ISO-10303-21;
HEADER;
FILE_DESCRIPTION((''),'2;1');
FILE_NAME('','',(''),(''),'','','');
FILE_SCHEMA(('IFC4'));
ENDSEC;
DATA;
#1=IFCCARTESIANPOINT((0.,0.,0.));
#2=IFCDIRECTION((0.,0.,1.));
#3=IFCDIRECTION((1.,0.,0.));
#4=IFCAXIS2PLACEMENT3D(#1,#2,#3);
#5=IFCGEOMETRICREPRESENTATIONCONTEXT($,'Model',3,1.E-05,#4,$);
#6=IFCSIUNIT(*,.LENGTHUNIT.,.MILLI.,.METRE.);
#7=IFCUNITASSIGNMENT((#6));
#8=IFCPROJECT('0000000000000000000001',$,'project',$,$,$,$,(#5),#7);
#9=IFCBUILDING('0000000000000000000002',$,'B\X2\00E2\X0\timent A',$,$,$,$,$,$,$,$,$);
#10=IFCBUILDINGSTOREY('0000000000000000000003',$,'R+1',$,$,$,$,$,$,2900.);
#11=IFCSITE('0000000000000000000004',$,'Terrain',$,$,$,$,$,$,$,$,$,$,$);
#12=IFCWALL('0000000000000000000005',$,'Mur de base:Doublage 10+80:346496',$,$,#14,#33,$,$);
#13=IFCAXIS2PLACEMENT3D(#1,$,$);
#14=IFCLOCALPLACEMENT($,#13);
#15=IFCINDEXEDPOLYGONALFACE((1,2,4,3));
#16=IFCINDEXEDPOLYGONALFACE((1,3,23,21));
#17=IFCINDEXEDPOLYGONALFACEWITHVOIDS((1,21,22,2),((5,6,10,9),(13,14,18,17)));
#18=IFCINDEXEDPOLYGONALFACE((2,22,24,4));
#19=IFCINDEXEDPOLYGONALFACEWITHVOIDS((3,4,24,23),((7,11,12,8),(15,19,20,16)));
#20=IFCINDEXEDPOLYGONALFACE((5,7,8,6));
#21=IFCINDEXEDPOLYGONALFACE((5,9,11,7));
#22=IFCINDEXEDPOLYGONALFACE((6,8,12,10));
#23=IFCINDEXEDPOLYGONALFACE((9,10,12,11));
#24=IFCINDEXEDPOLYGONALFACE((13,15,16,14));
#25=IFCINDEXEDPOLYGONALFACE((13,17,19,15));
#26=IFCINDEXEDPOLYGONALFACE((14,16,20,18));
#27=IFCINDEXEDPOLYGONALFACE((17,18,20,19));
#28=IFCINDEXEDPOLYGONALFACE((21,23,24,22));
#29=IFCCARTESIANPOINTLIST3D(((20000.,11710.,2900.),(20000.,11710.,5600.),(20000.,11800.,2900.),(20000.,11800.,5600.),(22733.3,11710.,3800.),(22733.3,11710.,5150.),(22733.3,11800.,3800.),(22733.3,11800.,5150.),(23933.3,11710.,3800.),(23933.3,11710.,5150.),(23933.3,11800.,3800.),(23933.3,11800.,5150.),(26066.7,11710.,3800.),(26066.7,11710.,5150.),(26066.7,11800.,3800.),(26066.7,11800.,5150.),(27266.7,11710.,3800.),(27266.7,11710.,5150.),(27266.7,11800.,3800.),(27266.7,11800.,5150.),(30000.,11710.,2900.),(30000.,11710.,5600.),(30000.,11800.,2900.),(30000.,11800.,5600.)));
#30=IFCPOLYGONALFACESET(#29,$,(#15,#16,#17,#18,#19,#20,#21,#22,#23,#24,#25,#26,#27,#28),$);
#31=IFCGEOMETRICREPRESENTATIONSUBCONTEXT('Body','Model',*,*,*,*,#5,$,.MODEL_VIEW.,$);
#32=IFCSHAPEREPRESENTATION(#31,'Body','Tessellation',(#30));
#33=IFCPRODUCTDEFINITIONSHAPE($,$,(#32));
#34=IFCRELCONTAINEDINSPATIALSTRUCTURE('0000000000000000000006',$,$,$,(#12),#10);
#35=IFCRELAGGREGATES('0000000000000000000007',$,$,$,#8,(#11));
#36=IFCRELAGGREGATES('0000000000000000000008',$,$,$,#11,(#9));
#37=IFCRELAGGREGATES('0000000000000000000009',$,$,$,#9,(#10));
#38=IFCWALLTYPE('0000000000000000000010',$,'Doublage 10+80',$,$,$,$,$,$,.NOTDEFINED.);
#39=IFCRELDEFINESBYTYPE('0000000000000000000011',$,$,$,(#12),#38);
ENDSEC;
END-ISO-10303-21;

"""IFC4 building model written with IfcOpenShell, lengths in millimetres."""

from ifc_helpers import new_model, si_unit, frame, frame_2d, origin_with_axes, place, context, subcontext, project, spatial, rectangle, extrude, type_object, element, save


model = new_model("IFC4")

# Units and contexts
model_context = context("Model", 3, precision=1e-05, world=origin_with_axes())
body_context = subcontext(model_context, "Body", "Model", "MODEL_VIEW")
ifc_project = project(units=[si_unit("LENGTHUNIT", "METRE", prefix="MILLI")], contexts=[model_context])

# Site, building, storey
site = spatial("IfcSite", under=ifc_project, Name="Terrain")
building = spatial("IfcBuilding", under=site, Name="Bâtiment A")
storey = spatial("IfcBuildingStorey", under=building, Name="R+1", Elevation=2900.0)

# Wall, openings
wall_type_1 = type_object("IfcWallType", Name="Doublage 10+80", PredefinedType="NOTDEFINED")
wall_1_placement = place(None, origin_with_axes())
wall_1 = element("IfcWall", 1, at=wall_1_placement, inside=storey, type_object=wall_type_1, Name="Mur de base:Doublage 10+80:346496", context=body_context, shape_type="SweptSolid", body=[
    extrude(rectangle(XDim=10000.0, YDim=90.0, at=frame_2d((25000.0, 11755.0))), frame((0.0, 0.0, 2900.0), z_axis=(0.0, 0.0, 1.0), x_axis=(1.0, 0.0, 0.0)), (0.0, 0.0, 1.0), 2700.0),
])
opening_1_placement = place(None, origin_with_axes())
element("IfcOpeningElement", 2, at=opening_1_placement, cuts=wall_1, context=body_context, shape_type="SweptSolid", body=[
    extrude(rectangle(XDim=1200.0, YDim=210.0, at=frame_2d((23333.3, 11755.0))), frame((0.0, 0.0, 3800.0), z_axis=(0.0, 0.0, 1.0), x_axis=(1.0, 0.0, 0.0)), (0.0, 0.0, 1.0), 1350.0),
])
opening_2_placement = place(None, origin_with_axes())
element("IfcOpeningElement", 3, at=opening_2_placement, cuts=wall_1, context=body_context, shape_type="SweptSolid", body=[
    extrude(rectangle(XDim=1200.0, YDim=210.0, at=frame_2d((26666.7, 11755.0))), frame((0.0, 0.0, 3800.0), z_axis=(0.0, 0.0, 1.0), x_axis=(1.0, 0.0, 0.0)), (0.0, 0.0, 1.0), 1350.0),
])

save(model, "model.ifc")
